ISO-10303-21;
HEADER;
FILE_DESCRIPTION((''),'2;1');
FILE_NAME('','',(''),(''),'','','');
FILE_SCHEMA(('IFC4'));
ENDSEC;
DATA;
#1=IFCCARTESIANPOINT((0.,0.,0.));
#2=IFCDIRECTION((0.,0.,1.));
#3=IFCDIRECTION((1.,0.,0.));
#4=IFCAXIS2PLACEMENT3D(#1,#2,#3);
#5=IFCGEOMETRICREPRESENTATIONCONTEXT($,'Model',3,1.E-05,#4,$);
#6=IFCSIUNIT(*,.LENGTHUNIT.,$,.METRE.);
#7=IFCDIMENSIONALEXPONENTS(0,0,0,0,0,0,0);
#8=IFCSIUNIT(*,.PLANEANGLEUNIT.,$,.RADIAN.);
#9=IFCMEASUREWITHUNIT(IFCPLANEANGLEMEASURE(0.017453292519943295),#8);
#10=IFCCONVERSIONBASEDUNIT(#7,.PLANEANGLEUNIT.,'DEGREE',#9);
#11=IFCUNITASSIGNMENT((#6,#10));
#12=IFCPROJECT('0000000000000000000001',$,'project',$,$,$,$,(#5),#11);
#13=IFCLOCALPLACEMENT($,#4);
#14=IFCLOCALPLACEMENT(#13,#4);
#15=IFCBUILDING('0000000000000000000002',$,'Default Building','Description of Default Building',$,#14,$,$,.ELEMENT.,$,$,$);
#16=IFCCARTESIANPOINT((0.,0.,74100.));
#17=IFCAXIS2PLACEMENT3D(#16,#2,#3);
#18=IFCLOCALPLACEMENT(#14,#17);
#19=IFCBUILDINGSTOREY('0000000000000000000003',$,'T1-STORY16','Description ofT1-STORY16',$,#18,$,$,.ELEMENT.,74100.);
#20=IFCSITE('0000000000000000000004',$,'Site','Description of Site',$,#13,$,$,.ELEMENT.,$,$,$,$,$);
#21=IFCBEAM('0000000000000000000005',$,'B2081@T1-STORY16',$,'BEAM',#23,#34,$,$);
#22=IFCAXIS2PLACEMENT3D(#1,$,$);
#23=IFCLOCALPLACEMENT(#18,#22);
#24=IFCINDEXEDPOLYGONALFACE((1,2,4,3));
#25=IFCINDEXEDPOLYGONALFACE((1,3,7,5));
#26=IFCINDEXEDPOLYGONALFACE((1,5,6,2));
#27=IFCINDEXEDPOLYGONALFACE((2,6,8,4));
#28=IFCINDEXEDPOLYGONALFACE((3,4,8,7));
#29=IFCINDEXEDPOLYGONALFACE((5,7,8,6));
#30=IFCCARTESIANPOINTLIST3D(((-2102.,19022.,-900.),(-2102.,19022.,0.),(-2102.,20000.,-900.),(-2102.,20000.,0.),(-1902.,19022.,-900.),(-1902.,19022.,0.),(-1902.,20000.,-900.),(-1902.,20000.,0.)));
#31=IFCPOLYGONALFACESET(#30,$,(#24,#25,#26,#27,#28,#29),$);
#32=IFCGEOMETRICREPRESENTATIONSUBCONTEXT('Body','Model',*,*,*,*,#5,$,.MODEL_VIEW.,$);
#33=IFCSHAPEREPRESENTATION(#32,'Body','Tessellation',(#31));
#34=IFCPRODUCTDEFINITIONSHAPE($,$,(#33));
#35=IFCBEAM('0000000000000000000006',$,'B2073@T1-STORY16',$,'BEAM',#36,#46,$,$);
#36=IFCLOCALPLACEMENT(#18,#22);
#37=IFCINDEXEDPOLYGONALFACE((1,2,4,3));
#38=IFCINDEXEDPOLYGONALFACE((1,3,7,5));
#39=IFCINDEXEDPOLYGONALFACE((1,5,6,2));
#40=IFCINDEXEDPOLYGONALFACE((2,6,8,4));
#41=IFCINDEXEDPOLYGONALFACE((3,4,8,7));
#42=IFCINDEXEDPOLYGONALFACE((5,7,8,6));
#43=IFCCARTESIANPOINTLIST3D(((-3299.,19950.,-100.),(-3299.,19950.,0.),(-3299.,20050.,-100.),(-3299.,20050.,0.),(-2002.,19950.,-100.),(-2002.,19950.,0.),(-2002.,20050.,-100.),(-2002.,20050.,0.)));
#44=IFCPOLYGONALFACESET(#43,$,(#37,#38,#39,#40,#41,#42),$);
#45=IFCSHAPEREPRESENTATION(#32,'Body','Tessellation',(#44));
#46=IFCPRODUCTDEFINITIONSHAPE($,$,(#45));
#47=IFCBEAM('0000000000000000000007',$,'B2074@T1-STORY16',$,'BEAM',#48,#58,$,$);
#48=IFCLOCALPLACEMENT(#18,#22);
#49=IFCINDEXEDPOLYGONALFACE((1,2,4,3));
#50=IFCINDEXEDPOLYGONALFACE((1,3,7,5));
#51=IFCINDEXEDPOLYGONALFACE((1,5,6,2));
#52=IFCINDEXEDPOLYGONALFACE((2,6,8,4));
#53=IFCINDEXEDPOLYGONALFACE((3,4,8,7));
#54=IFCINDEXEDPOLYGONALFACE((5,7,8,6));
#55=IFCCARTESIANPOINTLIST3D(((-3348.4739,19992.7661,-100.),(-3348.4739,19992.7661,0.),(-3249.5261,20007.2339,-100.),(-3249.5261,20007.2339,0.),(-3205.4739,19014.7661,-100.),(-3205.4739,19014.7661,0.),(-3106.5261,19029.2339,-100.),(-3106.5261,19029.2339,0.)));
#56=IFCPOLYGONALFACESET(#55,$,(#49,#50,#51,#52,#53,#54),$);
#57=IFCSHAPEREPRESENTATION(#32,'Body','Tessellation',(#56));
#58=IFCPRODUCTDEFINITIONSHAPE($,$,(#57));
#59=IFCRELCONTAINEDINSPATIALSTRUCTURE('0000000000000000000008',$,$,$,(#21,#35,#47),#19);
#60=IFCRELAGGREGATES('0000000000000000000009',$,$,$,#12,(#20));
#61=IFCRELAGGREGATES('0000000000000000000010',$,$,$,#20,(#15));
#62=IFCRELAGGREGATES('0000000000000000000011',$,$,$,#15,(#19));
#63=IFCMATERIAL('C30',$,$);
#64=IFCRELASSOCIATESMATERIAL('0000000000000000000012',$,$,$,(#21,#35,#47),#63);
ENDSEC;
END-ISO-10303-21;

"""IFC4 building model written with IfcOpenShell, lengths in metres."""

from ifc_helpers import new_model, entity, si_unit, converted_unit, frame, origin_with_axes, place, context, subcontext, project, spatial, rectangle, extrude, material, element, save


model = new_model("IFC4")

# Units and contexts
model_context = context("Model", 3, precision=1e-05, world=origin_with_axes())
body_context = subcontext(model_context, "Body", "Model", "MODEL_VIEW")
ifc_project = project(units=[si_unit("LENGTHUNIT", "METRE"), converted_unit("PLANEANGLEUNIT", "DEGREE", entity("IfcPlaneAngleMeasure", 0.017453292519943295), si_unit("PLANEANGLEUNIT", "RADIAN"), dimensions=[0, 0, 0, 0, 0, 0, 0])], contexts=[model_context])

# Site, building, storey
site_placement = place(None, origin_with_axes())
site = spatial("IfcSite", under=ifc_project, at=site_placement, Name="Site", Description="Description of Site", CompositionType="ELEMENT")
building_placement = place(site_placement, origin_with_axes())
building = spatial("IfcBuilding", under=site, at=building_placement, Name="Default Building", Description="Description of Default Building", CompositionType="ELEMENT")
storey_placement = place(building_placement, frame((0.0, 0.0, 74100.0), z_axis=(0.0, 0.0, 1.0), x_axis=(1.0, 0.0, 0.0)))
storey = spatial("IfcBuildingStorey", under=building, at=storey_placement, Name="T1-STORY16", Description="Description ofT1-STORY16", CompositionType="ELEMENT", Elevation=74100.0)

# Beams
ifc_material_1 = material(Name="C30")
beam_1_placement = place(storey_placement, frame((-2002.0, 19022.0, -450.0), z_axis=(0.0, 1.0, 0.0), x_axis=(-1.0, 0.0, 0.0)))
element("IfcBeam", 1, at=beam_1_placement, inside=storey, material=ifc_material_1, Name="B2081@T1-STORY16", ObjectType="BEAM", context=body_context, shape_type="SweptSolid", body=[
    extrude(rectangle(XDim=200.0, YDim=900.0), origin_with_axes(), (0.0, 0.0, 1.0), 978.0),
])
beam_2_placement = place(storey_placement, frame((-3299.0, 20000.0, -50.0), z_axis=(1.0, 0.0, 0.0), x_axis=(0.0, 1.0, 0.0)))
element("IfcBeam", 2, at=beam_2_placement, inside=storey, material=ifc_material_1, Name="B2073@T1-STORY16", ObjectType="BEAM", context=body_context, shape_type="SweptSolid", body=[
    extrude(rectangle(XDim=100.0, YDim=100.0), origin_with_axes(), (0.0, 0.0, 1.0), 1297.0),
])
beam_3_placement = place(storey_placement, frame((-3299.0, 20000.0, -50.0), z_axis=(0.144678, -0.989479, 0.0), x_axis=(0.989479, 0.144678, 0.0)))
element("IfcBeam", 3, at=beam_3_placement, inside=storey, material=ifc_material_1, Name="B2074@T1-STORY16", ObjectType="BEAM", context=body_context, shape_type="SweptSolid", body=[
    extrude(rectangle(XDim=100.0, YDim=100.0), origin_with_axes(), (0.0, 0.0, 1.0), 988.3992),
])

save(model, "model.ifc")
